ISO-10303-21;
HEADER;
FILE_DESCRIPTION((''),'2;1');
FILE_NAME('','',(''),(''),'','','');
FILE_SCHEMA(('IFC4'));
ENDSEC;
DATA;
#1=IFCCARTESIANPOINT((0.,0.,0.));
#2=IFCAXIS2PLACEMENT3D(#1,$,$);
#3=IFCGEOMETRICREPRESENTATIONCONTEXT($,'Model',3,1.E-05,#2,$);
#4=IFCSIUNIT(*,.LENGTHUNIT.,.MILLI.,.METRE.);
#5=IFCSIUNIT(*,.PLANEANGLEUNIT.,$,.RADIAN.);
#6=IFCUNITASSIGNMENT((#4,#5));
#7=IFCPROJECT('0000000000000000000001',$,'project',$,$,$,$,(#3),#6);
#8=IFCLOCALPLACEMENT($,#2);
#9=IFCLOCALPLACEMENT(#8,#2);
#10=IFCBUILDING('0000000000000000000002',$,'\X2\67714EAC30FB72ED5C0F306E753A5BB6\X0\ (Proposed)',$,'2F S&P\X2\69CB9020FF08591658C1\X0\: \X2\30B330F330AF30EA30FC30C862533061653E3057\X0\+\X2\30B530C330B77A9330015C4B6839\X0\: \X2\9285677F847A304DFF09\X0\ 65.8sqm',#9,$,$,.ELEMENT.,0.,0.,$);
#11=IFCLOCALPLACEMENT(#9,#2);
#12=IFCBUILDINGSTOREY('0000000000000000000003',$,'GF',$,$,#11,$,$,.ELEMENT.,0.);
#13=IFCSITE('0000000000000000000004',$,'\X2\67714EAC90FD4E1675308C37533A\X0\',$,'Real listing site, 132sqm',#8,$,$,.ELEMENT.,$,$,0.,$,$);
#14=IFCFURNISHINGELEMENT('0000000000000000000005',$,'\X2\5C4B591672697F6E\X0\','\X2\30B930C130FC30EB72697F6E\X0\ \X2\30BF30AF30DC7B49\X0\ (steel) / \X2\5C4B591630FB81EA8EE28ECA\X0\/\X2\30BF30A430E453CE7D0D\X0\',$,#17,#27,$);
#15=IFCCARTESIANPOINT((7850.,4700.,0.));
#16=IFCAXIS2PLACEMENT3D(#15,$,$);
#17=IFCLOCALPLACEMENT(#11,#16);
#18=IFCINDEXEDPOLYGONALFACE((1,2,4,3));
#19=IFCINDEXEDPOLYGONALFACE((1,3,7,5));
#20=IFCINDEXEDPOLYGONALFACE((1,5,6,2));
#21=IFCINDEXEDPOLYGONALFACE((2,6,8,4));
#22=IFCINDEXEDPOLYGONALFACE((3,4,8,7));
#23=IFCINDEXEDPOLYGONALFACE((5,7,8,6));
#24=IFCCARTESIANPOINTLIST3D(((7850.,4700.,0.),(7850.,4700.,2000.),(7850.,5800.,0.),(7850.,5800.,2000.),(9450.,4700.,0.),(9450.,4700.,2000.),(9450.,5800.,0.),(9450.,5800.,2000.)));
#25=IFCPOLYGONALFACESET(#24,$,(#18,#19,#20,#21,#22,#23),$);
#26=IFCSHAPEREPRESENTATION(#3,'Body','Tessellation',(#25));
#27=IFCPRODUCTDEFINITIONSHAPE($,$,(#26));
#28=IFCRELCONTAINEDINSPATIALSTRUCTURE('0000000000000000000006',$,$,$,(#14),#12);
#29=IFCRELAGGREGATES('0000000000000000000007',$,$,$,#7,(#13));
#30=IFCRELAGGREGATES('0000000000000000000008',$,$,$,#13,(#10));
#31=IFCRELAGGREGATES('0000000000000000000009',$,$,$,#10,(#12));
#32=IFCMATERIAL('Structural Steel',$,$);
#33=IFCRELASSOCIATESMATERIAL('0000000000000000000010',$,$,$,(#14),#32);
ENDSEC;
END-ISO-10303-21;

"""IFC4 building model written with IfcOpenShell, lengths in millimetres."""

from ifc_helpers import new_model, si_unit, frame, frame_2d, origin, place, context, project, spatial, rectangle, extrude, material, element, save


model = new_model("IFC4")

# Units and contexts
model_context = context("Model", 3, precision=1e-05, world=origin())
ifc_project = project(units=[si_unit("LENGTHUNIT", "METRE", prefix="MILLI"), si_unit("PLANEANGLEUNIT", "RADIAN")], contexts=[model_context])

# Site, building, storey
site_placement = place(None, origin())
site = spatial("IfcSite", under=ifc_project, at=site_placement, Name="東京都世田谷区", ObjectType="Real listing site, 132sqm", CompositionType="ELEMENT", RefElevation=0.0)
building_placement = place(site_placement, origin())
building = spatial("IfcBuilding", under=site, at=building_placement, Name="東京・狭小の町家 (Proposed)", ObjectType="2F S&P構造（外壁: コンクリート打ち放し+サッシ窓、屋根: 銅板葺き） 65.8sqm", CompositionType="ELEMENT", ElevationOfRefHeight=0.0, ElevationOfTerrain=0.0)
storey_placement = place(building_placement, origin())
storey = spatial("IfcBuildingStorey", under=building, at=storey_placement, Name="GF", CompositionType="ELEMENT", Elevation=0.0)

# Shared definitions
ifc_material_1 = material(Name="Structural Steel")

# Furnishing element
furnishing_1_placement = place(storey_placement, frame((7850.0, 4700.0, 0.0)))
element("IfcFurnishingElement", 1, at=furnishing_1_placement, inside=storey, material=ifc_material_1, Name="屋外物置", Description="スチール物置 タクボ等 (steel) / 屋外・自転車/タイヤ収納", context=model_context, shape_type="SweptSolid", body=[
    extrude(rectangle(XDim=1600.0, YDim=1100.0, at=frame_2d((800.0, 550.0))), frame((7850.0, 4700.0, 0.0)), (0.0, 0.0, 1.0), 2000.0),
])

save(model, "model.ifc")
